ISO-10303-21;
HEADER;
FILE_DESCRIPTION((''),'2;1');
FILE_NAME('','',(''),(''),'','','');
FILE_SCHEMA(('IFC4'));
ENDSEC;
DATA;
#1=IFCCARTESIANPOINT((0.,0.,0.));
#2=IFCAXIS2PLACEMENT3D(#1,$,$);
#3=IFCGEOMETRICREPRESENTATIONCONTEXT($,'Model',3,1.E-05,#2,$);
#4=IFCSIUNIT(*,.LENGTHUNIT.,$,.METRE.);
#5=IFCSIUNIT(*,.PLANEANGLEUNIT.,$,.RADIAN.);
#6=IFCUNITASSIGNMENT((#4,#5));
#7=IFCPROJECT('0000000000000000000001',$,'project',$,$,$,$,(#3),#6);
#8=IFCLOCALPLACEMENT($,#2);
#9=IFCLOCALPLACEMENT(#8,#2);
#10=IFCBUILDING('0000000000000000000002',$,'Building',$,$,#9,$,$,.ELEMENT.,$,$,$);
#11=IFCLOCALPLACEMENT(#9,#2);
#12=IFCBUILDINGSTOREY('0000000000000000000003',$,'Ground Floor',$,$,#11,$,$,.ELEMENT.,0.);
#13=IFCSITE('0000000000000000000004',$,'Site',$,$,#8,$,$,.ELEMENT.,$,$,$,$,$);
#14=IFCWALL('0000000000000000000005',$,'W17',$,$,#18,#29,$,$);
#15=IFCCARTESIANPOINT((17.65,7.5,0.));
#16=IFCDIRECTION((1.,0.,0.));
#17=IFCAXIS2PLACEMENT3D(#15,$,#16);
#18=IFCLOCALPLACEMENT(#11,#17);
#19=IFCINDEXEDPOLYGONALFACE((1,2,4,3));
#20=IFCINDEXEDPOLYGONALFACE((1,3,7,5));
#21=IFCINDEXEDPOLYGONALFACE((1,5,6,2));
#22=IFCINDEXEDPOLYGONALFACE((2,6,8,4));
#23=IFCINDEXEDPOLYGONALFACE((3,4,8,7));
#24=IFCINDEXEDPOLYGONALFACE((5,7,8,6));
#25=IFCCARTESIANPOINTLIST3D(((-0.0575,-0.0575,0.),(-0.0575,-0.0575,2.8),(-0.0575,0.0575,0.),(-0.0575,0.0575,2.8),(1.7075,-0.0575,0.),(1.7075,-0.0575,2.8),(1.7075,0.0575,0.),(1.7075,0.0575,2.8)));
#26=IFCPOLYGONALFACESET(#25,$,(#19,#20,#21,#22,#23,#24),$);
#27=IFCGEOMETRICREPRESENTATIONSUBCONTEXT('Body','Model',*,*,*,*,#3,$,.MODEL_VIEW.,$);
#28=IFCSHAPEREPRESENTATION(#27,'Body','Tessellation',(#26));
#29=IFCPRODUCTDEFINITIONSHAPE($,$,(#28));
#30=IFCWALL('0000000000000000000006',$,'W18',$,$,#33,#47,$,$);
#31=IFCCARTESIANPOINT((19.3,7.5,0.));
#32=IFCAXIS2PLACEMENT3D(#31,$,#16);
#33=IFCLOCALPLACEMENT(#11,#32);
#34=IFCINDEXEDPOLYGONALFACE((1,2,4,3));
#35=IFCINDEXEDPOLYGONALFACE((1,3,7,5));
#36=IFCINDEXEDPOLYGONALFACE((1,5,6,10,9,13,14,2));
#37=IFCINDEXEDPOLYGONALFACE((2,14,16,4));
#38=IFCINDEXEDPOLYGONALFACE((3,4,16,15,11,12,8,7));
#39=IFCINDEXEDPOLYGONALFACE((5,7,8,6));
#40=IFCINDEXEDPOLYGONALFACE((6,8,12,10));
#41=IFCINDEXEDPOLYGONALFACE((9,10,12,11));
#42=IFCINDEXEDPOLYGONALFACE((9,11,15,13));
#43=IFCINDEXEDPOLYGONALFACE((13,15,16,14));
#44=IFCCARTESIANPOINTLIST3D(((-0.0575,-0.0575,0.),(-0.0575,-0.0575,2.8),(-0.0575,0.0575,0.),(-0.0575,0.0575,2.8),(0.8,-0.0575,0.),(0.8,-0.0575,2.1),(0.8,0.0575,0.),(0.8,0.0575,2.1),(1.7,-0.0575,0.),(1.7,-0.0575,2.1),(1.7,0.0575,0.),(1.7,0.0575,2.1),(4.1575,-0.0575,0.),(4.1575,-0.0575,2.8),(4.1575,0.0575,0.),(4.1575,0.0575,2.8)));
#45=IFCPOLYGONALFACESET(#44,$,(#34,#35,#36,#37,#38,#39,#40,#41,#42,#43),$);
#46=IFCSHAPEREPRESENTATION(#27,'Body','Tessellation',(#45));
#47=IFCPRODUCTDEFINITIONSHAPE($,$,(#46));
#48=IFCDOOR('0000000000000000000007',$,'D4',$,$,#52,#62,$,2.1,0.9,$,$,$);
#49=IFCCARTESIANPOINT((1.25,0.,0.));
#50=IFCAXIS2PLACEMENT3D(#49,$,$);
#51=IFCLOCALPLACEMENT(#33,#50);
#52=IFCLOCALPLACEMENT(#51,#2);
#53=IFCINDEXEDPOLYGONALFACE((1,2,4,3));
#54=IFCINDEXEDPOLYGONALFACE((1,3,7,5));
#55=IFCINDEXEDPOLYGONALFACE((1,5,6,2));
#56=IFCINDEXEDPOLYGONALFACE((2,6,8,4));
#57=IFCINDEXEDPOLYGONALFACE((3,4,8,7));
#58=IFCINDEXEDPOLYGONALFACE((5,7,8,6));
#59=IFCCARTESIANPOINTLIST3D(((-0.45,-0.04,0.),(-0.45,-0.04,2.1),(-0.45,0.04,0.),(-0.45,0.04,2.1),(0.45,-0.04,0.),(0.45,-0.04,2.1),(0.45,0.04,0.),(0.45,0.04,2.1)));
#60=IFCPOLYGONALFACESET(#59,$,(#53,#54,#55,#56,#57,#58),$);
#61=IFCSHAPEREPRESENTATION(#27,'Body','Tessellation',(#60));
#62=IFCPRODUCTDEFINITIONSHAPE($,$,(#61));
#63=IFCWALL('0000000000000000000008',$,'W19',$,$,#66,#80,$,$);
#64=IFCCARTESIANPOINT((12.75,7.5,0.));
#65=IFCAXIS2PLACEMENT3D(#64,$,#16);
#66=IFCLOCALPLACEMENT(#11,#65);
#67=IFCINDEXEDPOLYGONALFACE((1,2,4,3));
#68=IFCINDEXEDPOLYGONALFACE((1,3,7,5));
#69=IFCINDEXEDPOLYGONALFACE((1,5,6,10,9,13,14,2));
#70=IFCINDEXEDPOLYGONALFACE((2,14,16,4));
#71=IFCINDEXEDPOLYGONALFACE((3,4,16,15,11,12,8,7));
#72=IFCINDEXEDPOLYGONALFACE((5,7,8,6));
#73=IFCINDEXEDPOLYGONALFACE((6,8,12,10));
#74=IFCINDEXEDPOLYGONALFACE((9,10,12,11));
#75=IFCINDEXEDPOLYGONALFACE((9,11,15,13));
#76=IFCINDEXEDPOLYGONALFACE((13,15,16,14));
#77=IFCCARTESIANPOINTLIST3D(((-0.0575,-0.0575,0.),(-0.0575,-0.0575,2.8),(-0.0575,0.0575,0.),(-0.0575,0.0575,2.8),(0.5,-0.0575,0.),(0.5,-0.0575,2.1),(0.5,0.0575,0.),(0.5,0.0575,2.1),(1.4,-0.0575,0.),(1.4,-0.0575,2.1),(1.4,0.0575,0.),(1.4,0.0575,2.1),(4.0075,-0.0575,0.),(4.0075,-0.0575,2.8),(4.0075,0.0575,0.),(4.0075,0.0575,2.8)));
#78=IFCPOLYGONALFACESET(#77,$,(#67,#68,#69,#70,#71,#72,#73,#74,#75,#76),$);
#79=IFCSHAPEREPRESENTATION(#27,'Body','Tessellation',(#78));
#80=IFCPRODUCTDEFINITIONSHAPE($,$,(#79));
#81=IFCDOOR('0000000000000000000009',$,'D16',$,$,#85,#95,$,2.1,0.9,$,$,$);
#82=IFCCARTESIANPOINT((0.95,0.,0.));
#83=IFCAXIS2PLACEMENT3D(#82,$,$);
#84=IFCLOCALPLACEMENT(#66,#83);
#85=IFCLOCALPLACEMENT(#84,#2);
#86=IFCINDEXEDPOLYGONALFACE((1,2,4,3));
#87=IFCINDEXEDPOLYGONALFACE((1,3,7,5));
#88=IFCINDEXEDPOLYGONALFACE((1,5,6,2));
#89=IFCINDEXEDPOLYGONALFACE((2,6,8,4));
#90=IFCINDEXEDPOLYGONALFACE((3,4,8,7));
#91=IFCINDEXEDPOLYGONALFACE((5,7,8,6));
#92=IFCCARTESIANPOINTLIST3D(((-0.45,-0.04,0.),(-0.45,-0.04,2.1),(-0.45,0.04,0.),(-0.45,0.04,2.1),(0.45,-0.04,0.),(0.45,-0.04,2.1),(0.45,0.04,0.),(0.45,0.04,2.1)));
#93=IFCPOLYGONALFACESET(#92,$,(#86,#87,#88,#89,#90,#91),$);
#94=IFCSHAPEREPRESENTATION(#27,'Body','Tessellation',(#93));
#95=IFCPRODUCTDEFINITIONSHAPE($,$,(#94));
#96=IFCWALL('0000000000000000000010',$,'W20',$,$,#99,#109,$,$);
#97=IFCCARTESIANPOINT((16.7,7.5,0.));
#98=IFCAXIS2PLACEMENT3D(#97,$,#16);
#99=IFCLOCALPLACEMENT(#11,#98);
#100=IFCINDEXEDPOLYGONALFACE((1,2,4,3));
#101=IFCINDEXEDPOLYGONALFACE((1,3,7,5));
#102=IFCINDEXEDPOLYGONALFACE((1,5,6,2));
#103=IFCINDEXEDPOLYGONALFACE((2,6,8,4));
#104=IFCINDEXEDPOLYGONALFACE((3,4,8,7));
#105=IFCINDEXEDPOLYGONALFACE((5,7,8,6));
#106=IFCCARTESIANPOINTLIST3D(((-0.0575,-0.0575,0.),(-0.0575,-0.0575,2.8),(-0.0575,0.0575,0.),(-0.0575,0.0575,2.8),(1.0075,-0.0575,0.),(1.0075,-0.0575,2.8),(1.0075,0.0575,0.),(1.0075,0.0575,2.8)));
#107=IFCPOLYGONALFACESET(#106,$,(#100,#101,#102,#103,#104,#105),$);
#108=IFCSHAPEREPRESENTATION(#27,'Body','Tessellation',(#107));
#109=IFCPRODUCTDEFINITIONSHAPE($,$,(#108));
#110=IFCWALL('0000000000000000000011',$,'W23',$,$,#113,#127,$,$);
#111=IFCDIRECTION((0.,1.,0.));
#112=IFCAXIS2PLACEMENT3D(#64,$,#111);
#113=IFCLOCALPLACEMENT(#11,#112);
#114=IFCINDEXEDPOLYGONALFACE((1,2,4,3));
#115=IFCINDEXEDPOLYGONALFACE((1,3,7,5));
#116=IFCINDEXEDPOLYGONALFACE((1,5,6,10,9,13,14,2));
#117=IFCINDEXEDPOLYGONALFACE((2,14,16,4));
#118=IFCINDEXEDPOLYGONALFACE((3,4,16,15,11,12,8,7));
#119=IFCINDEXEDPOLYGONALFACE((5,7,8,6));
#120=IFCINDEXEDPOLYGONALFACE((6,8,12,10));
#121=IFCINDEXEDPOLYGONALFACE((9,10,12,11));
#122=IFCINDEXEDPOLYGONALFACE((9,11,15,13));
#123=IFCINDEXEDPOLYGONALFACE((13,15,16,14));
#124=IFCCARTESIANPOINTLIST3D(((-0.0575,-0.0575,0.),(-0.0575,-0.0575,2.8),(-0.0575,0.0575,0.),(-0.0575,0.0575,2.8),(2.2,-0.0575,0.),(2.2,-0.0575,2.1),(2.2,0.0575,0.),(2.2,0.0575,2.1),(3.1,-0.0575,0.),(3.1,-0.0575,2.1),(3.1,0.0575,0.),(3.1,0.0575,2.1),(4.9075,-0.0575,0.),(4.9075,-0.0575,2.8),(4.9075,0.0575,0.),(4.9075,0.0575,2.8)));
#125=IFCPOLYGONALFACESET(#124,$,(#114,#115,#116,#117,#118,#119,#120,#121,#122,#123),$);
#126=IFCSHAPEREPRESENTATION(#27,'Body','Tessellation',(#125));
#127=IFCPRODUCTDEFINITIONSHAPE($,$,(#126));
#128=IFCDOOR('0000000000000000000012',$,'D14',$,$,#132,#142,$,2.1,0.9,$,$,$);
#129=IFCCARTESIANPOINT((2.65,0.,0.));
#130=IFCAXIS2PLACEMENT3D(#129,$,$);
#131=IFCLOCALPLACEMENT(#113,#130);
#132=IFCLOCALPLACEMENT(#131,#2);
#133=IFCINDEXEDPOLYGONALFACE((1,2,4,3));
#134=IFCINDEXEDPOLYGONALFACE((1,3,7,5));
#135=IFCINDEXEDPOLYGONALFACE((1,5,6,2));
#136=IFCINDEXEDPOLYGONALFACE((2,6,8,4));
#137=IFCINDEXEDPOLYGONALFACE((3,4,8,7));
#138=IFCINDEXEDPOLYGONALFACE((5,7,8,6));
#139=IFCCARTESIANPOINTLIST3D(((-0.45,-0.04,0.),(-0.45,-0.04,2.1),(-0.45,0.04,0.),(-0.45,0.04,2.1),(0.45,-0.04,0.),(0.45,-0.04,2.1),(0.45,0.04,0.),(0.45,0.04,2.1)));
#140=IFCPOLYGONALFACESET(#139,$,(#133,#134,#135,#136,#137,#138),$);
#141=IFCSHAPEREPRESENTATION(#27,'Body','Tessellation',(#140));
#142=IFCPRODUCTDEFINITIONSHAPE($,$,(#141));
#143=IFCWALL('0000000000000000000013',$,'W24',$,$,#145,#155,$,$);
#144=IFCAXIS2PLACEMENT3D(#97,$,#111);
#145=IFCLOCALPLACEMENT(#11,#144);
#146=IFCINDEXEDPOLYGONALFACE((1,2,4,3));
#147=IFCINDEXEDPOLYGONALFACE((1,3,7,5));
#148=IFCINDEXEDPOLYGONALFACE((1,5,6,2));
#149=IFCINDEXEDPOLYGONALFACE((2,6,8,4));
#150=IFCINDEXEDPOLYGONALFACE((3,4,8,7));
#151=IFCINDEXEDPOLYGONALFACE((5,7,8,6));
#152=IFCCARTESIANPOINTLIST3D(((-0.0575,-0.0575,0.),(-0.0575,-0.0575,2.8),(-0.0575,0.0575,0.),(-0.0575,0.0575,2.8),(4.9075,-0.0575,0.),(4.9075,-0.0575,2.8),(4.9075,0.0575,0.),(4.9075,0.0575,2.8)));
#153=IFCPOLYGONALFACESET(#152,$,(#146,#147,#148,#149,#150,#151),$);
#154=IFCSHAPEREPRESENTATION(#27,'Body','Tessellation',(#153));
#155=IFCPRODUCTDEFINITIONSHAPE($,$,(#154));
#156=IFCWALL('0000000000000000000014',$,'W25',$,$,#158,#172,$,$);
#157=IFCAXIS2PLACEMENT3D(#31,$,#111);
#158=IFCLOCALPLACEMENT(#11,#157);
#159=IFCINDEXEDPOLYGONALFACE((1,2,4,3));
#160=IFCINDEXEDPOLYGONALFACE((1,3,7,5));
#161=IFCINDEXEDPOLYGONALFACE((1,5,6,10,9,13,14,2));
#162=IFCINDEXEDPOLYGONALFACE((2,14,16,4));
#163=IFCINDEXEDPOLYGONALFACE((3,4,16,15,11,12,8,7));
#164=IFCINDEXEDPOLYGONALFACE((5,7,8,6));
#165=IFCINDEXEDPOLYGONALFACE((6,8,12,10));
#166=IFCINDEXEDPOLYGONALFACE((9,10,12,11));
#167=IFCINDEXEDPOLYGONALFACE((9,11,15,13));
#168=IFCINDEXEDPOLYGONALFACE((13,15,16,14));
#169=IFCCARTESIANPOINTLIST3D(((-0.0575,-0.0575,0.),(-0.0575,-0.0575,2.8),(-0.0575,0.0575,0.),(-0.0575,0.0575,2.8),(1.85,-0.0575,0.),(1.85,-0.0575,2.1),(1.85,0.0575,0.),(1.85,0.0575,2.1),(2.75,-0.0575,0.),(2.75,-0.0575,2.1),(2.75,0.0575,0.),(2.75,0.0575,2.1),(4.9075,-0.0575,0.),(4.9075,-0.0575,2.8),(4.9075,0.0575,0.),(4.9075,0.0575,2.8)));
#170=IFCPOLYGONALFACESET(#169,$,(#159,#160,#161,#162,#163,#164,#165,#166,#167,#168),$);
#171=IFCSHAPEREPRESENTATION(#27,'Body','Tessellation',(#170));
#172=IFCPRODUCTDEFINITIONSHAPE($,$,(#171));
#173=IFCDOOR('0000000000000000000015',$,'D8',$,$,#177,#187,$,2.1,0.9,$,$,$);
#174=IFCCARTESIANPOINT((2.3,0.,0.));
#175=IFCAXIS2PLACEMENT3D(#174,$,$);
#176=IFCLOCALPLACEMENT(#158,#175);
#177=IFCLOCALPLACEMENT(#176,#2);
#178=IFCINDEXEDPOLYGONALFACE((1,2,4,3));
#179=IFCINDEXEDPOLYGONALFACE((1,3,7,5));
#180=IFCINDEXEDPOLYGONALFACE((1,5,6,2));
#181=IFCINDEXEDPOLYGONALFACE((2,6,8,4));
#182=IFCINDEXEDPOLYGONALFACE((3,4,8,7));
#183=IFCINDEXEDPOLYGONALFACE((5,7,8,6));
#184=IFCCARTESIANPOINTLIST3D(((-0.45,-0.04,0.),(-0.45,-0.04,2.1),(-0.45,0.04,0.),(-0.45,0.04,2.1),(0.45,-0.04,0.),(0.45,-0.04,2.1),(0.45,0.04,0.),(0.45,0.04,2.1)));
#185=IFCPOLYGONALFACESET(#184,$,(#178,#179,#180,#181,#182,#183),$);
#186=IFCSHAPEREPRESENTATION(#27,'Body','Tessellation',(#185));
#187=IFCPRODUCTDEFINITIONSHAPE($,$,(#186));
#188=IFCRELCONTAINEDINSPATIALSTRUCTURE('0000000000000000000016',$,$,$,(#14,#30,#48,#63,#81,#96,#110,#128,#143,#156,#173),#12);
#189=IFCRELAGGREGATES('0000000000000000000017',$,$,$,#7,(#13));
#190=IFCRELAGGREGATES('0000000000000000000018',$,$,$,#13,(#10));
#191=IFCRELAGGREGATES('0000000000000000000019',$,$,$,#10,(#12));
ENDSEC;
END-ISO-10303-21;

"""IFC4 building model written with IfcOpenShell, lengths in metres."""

from ifc_helpers import new_model, si_unit, frame, frame_2d, origin, origin_2d, place, context, subcontext, project, spatial, rectangle, extrude, element, fill, save


model = new_model("IFC4")

# Units and contexts
model_context = context("Model", 3, precision=1e-05, world=origin())
body_context = subcontext(model_context, "Body", "Model", "MODEL_VIEW")
ifc_project = project(units=[si_unit("LENGTHUNIT", "METRE"), si_unit("PLANEANGLEUNIT", "RADIAN")], contexts=[model_context])

# Site, building, storey
site_placement = place(None, origin())
site = spatial("IfcSite", under=ifc_project, at=site_placement, Name="Site", CompositionType="ELEMENT")
building_placement = place(site_placement, origin())
building = spatial("IfcBuilding", under=site, at=building_placement, Name="Building", CompositionType="ELEMENT")
storey_placement = place(building_placement, origin())
storey = spatial("IfcBuildingStorey", under=building, at=storey_placement, Name="Ground Floor", CompositionType="ELEMENT", Elevation=0.0)

# Wall
wall_1_placement = place(storey_placement, frame((17.65, 7.5, 0.0), x_axis=(1.0, 0.0, 0.0)))
element("IfcWall", 1, at=wall_1_placement, inside=storey, Name="W17", context=body_context, shape_type="SweptSolid", body=[
    extrude(rectangle(XDim=1.765, YDim=0.115, at=frame_2d((0.825, 0.0))), origin(), (0.0, 0.0, 1.0), 2.8),
])

# Walls, openings, doors
wall_2_placement = place(storey_placement, frame((19.3, 7.5, 0.0), x_axis=(1.0, 0.0, 0.0)))
wall_2 = element("IfcWall", 2, at=wall_2_placement, inside=storey, Name="W18", context=body_context, shape_type="SweptSolid", body=[
    extrude(rectangle(XDim=4.215, YDim=0.115, at=frame_2d((2.05, 0.0))), origin(), (0.0, 0.0, 1.0), 2.8),
])
opening_1_placement = place(wall_2_placement, frame((1.25, 0.0, 0.0)))
opening_1 = element("IfcOpeningElement", 3, at=opening_1_placement, cuts=wall_2, context=body_context, shape_type="SweptSolid", body=[
    extrude(rectangle(XDim=0.9, YDim=0.215, at=origin_2d()), origin(), (0.0, 0.0, 1.0), 2.1),
])
door_1_placement = place(opening_1_placement, origin())
door_1 = element("IfcDoor", 4, at=door_1_placement, inside=storey, Name="D4", OverallHeight=2.1, OverallWidth=0.9, context=body_context, shape_type="SweptSolid", body=[
    extrude(rectangle(XDim=0.9, YDim=0.08, at=origin_2d()), origin(), (0.0, 0.0, 1.0), 2.1),
])
fill(opening_1, door_1)
wall_3_placement = place(storey_placement, frame((12.75, 7.5, 0.0), x_axis=(1.0, 0.0, 0.0)))
wall_3 = element("IfcWall", 5, at=wall_3_placement, inside=storey, Name="W19", context=body_context, shape_type="SweptSolid", body=[
    extrude(rectangle(XDim=4.065, YDim=0.115, at=frame_2d((1.975, 0.0))), origin(), (0.0, 0.0, 1.0), 2.8),
])
opening_2_placement = place(wall_3_placement, frame((0.95, 0.0, 0.0)))
opening_2 = element("IfcOpeningElement", 6, at=opening_2_placement, cuts=wall_3, context=body_context, shape_type="SweptSolid", body=[
    extrude(rectangle(XDim=0.9, YDim=0.215, at=origin_2d()), origin(), (0.0, 0.0, 1.0), 2.1),
])
door_2_placement = place(opening_2_placement, origin())
door_2 = element("IfcDoor", 7, at=door_2_placement, inside=storey, Name="D16", OverallHeight=2.1, OverallWidth=0.9, context=body_context, shape_type="SweptSolid", body=[
    extrude(rectangle(XDim=0.9, YDim=0.08, at=origin_2d()), origin(), (0.0, 0.0, 1.0), 2.1),
])
fill(opening_2, door_2)

# Wall
wall_4_placement = place(storey_placement, frame((16.7, 7.5, 0.0), x_axis=(1.0, 0.0, 0.0)))
element("IfcWall", 8, at=wall_4_placement, inside=storey, Name="W20", context=body_context, shape_type="SweptSolid", body=[
    extrude(rectangle(XDim=1.065, YDim=0.115, at=frame_2d((0.475, 0.0))), origin(), (0.0, 0.0, 1.0), 2.8),
])

# Wall, opening, door
wall_5_placement = place(storey_placement, frame((12.75, 7.5, 0.0), x_axis=(0.0, 1.0, 0.0)))
wall_5 = element("IfcWall", 9, at=wall_5_placement, inside=storey, Name="W23", context=body_context, shape_type="SweptSolid", body=[
    extrude(rectangle(XDim=4.965, YDim=0.115, at=frame_2d((2.425, 0.0))), origin(), (0.0, 0.0, 1.0), 2.8),
])
opening_3_placement = place(wall_5_placement, frame((2.65, 0.0, 0.0)))
opening_3 = element("IfcOpeningElement", 10, at=opening_3_placement, cuts=wall_5, context=body_context, shape_type="SweptSolid", body=[
    extrude(rectangle(XDim=0.9, YDim=0.215, at=origin_2d()), origin(), (0.0, 0.0, 1.0), 2.1),
])
door_3_placement = place(opening_3_placement, origin())
door_3 = element("IfcDoor", 11, at=door_3_placement, inside=storey, Name="D14", OverallHeight=2.1, OverallWidth=0.9, context=body_context, shape_type="SweptSolid", body=[
    extrude(rectangle(XDim=0.9, YDim=0.08, at=origin_2d()), origin(), (0.0, 0.0, 1.0), 2.1),
])
fill(opening_3, door_3)

# Wall
wall_6_placement = place(storey_placement, frame((16.7, 7.5, 0.0), x_axis=(0.0, 1.0, 0.0)))
element("IfcWall", 12, at=wall_6_placement, inside=storey, Name="W24", context=body_context, shape_type="SweptSolid", body=[
    extrude(rectangle(XDim=4.965, YDim=0.115, at=frame_2d((2.425, 0.0))), origin(), (0.0, 0.0, 1.0), 2.8),
])

# Wall, opening, door
wall_7_placement = place(storey_placement, frame((19.3, 7.5, 0.0), x_axis=(0.0, 1.0, 0.0)))
wall_7 = element("IfcWall", 13, at=wall_7_placement, inside=storey, Name="W25", context=body_context, shape_type="SweptSolid", body=[
    extrude(rectangle(XDim=4.965, YDim=0.115, at=frame_2d((2.425, 0.0))), origin(), (0.0, 0.0, 1.0), 2.8),
])
opening_4_placement = place(wall_7_placement, frame((2.3, 0.0, 0.0)))
opening_4 = element("IfcOpeningElement", 14, at=opening_4_placement, cuts=wall_7, context=body_context, shape_type="SweptSolid", body=[
    extrude(rectangle(XDim=0.9, YDim=0.215, at=origin_2d()), origin(), (0.0, 0.0, 1.0), 2.1),
])
door_4_placement = place(opening_4_placement, origin())
door_4 = element("IfcDoor", 15, at=door_4_placement, inside=storey, Name="D8", OverallHeight=2.1, OverallWidth=0.9, context=body_context, shape_type="SweptSolid", body=[
    extrude(rectangle(XDim=0.9, YDim=0.08, at=origin_2d()), origin(), (0.0, 0.0, 1.0), 2.1),
])
fill(opening_4, door_4)

save(model, "model.ifc")
